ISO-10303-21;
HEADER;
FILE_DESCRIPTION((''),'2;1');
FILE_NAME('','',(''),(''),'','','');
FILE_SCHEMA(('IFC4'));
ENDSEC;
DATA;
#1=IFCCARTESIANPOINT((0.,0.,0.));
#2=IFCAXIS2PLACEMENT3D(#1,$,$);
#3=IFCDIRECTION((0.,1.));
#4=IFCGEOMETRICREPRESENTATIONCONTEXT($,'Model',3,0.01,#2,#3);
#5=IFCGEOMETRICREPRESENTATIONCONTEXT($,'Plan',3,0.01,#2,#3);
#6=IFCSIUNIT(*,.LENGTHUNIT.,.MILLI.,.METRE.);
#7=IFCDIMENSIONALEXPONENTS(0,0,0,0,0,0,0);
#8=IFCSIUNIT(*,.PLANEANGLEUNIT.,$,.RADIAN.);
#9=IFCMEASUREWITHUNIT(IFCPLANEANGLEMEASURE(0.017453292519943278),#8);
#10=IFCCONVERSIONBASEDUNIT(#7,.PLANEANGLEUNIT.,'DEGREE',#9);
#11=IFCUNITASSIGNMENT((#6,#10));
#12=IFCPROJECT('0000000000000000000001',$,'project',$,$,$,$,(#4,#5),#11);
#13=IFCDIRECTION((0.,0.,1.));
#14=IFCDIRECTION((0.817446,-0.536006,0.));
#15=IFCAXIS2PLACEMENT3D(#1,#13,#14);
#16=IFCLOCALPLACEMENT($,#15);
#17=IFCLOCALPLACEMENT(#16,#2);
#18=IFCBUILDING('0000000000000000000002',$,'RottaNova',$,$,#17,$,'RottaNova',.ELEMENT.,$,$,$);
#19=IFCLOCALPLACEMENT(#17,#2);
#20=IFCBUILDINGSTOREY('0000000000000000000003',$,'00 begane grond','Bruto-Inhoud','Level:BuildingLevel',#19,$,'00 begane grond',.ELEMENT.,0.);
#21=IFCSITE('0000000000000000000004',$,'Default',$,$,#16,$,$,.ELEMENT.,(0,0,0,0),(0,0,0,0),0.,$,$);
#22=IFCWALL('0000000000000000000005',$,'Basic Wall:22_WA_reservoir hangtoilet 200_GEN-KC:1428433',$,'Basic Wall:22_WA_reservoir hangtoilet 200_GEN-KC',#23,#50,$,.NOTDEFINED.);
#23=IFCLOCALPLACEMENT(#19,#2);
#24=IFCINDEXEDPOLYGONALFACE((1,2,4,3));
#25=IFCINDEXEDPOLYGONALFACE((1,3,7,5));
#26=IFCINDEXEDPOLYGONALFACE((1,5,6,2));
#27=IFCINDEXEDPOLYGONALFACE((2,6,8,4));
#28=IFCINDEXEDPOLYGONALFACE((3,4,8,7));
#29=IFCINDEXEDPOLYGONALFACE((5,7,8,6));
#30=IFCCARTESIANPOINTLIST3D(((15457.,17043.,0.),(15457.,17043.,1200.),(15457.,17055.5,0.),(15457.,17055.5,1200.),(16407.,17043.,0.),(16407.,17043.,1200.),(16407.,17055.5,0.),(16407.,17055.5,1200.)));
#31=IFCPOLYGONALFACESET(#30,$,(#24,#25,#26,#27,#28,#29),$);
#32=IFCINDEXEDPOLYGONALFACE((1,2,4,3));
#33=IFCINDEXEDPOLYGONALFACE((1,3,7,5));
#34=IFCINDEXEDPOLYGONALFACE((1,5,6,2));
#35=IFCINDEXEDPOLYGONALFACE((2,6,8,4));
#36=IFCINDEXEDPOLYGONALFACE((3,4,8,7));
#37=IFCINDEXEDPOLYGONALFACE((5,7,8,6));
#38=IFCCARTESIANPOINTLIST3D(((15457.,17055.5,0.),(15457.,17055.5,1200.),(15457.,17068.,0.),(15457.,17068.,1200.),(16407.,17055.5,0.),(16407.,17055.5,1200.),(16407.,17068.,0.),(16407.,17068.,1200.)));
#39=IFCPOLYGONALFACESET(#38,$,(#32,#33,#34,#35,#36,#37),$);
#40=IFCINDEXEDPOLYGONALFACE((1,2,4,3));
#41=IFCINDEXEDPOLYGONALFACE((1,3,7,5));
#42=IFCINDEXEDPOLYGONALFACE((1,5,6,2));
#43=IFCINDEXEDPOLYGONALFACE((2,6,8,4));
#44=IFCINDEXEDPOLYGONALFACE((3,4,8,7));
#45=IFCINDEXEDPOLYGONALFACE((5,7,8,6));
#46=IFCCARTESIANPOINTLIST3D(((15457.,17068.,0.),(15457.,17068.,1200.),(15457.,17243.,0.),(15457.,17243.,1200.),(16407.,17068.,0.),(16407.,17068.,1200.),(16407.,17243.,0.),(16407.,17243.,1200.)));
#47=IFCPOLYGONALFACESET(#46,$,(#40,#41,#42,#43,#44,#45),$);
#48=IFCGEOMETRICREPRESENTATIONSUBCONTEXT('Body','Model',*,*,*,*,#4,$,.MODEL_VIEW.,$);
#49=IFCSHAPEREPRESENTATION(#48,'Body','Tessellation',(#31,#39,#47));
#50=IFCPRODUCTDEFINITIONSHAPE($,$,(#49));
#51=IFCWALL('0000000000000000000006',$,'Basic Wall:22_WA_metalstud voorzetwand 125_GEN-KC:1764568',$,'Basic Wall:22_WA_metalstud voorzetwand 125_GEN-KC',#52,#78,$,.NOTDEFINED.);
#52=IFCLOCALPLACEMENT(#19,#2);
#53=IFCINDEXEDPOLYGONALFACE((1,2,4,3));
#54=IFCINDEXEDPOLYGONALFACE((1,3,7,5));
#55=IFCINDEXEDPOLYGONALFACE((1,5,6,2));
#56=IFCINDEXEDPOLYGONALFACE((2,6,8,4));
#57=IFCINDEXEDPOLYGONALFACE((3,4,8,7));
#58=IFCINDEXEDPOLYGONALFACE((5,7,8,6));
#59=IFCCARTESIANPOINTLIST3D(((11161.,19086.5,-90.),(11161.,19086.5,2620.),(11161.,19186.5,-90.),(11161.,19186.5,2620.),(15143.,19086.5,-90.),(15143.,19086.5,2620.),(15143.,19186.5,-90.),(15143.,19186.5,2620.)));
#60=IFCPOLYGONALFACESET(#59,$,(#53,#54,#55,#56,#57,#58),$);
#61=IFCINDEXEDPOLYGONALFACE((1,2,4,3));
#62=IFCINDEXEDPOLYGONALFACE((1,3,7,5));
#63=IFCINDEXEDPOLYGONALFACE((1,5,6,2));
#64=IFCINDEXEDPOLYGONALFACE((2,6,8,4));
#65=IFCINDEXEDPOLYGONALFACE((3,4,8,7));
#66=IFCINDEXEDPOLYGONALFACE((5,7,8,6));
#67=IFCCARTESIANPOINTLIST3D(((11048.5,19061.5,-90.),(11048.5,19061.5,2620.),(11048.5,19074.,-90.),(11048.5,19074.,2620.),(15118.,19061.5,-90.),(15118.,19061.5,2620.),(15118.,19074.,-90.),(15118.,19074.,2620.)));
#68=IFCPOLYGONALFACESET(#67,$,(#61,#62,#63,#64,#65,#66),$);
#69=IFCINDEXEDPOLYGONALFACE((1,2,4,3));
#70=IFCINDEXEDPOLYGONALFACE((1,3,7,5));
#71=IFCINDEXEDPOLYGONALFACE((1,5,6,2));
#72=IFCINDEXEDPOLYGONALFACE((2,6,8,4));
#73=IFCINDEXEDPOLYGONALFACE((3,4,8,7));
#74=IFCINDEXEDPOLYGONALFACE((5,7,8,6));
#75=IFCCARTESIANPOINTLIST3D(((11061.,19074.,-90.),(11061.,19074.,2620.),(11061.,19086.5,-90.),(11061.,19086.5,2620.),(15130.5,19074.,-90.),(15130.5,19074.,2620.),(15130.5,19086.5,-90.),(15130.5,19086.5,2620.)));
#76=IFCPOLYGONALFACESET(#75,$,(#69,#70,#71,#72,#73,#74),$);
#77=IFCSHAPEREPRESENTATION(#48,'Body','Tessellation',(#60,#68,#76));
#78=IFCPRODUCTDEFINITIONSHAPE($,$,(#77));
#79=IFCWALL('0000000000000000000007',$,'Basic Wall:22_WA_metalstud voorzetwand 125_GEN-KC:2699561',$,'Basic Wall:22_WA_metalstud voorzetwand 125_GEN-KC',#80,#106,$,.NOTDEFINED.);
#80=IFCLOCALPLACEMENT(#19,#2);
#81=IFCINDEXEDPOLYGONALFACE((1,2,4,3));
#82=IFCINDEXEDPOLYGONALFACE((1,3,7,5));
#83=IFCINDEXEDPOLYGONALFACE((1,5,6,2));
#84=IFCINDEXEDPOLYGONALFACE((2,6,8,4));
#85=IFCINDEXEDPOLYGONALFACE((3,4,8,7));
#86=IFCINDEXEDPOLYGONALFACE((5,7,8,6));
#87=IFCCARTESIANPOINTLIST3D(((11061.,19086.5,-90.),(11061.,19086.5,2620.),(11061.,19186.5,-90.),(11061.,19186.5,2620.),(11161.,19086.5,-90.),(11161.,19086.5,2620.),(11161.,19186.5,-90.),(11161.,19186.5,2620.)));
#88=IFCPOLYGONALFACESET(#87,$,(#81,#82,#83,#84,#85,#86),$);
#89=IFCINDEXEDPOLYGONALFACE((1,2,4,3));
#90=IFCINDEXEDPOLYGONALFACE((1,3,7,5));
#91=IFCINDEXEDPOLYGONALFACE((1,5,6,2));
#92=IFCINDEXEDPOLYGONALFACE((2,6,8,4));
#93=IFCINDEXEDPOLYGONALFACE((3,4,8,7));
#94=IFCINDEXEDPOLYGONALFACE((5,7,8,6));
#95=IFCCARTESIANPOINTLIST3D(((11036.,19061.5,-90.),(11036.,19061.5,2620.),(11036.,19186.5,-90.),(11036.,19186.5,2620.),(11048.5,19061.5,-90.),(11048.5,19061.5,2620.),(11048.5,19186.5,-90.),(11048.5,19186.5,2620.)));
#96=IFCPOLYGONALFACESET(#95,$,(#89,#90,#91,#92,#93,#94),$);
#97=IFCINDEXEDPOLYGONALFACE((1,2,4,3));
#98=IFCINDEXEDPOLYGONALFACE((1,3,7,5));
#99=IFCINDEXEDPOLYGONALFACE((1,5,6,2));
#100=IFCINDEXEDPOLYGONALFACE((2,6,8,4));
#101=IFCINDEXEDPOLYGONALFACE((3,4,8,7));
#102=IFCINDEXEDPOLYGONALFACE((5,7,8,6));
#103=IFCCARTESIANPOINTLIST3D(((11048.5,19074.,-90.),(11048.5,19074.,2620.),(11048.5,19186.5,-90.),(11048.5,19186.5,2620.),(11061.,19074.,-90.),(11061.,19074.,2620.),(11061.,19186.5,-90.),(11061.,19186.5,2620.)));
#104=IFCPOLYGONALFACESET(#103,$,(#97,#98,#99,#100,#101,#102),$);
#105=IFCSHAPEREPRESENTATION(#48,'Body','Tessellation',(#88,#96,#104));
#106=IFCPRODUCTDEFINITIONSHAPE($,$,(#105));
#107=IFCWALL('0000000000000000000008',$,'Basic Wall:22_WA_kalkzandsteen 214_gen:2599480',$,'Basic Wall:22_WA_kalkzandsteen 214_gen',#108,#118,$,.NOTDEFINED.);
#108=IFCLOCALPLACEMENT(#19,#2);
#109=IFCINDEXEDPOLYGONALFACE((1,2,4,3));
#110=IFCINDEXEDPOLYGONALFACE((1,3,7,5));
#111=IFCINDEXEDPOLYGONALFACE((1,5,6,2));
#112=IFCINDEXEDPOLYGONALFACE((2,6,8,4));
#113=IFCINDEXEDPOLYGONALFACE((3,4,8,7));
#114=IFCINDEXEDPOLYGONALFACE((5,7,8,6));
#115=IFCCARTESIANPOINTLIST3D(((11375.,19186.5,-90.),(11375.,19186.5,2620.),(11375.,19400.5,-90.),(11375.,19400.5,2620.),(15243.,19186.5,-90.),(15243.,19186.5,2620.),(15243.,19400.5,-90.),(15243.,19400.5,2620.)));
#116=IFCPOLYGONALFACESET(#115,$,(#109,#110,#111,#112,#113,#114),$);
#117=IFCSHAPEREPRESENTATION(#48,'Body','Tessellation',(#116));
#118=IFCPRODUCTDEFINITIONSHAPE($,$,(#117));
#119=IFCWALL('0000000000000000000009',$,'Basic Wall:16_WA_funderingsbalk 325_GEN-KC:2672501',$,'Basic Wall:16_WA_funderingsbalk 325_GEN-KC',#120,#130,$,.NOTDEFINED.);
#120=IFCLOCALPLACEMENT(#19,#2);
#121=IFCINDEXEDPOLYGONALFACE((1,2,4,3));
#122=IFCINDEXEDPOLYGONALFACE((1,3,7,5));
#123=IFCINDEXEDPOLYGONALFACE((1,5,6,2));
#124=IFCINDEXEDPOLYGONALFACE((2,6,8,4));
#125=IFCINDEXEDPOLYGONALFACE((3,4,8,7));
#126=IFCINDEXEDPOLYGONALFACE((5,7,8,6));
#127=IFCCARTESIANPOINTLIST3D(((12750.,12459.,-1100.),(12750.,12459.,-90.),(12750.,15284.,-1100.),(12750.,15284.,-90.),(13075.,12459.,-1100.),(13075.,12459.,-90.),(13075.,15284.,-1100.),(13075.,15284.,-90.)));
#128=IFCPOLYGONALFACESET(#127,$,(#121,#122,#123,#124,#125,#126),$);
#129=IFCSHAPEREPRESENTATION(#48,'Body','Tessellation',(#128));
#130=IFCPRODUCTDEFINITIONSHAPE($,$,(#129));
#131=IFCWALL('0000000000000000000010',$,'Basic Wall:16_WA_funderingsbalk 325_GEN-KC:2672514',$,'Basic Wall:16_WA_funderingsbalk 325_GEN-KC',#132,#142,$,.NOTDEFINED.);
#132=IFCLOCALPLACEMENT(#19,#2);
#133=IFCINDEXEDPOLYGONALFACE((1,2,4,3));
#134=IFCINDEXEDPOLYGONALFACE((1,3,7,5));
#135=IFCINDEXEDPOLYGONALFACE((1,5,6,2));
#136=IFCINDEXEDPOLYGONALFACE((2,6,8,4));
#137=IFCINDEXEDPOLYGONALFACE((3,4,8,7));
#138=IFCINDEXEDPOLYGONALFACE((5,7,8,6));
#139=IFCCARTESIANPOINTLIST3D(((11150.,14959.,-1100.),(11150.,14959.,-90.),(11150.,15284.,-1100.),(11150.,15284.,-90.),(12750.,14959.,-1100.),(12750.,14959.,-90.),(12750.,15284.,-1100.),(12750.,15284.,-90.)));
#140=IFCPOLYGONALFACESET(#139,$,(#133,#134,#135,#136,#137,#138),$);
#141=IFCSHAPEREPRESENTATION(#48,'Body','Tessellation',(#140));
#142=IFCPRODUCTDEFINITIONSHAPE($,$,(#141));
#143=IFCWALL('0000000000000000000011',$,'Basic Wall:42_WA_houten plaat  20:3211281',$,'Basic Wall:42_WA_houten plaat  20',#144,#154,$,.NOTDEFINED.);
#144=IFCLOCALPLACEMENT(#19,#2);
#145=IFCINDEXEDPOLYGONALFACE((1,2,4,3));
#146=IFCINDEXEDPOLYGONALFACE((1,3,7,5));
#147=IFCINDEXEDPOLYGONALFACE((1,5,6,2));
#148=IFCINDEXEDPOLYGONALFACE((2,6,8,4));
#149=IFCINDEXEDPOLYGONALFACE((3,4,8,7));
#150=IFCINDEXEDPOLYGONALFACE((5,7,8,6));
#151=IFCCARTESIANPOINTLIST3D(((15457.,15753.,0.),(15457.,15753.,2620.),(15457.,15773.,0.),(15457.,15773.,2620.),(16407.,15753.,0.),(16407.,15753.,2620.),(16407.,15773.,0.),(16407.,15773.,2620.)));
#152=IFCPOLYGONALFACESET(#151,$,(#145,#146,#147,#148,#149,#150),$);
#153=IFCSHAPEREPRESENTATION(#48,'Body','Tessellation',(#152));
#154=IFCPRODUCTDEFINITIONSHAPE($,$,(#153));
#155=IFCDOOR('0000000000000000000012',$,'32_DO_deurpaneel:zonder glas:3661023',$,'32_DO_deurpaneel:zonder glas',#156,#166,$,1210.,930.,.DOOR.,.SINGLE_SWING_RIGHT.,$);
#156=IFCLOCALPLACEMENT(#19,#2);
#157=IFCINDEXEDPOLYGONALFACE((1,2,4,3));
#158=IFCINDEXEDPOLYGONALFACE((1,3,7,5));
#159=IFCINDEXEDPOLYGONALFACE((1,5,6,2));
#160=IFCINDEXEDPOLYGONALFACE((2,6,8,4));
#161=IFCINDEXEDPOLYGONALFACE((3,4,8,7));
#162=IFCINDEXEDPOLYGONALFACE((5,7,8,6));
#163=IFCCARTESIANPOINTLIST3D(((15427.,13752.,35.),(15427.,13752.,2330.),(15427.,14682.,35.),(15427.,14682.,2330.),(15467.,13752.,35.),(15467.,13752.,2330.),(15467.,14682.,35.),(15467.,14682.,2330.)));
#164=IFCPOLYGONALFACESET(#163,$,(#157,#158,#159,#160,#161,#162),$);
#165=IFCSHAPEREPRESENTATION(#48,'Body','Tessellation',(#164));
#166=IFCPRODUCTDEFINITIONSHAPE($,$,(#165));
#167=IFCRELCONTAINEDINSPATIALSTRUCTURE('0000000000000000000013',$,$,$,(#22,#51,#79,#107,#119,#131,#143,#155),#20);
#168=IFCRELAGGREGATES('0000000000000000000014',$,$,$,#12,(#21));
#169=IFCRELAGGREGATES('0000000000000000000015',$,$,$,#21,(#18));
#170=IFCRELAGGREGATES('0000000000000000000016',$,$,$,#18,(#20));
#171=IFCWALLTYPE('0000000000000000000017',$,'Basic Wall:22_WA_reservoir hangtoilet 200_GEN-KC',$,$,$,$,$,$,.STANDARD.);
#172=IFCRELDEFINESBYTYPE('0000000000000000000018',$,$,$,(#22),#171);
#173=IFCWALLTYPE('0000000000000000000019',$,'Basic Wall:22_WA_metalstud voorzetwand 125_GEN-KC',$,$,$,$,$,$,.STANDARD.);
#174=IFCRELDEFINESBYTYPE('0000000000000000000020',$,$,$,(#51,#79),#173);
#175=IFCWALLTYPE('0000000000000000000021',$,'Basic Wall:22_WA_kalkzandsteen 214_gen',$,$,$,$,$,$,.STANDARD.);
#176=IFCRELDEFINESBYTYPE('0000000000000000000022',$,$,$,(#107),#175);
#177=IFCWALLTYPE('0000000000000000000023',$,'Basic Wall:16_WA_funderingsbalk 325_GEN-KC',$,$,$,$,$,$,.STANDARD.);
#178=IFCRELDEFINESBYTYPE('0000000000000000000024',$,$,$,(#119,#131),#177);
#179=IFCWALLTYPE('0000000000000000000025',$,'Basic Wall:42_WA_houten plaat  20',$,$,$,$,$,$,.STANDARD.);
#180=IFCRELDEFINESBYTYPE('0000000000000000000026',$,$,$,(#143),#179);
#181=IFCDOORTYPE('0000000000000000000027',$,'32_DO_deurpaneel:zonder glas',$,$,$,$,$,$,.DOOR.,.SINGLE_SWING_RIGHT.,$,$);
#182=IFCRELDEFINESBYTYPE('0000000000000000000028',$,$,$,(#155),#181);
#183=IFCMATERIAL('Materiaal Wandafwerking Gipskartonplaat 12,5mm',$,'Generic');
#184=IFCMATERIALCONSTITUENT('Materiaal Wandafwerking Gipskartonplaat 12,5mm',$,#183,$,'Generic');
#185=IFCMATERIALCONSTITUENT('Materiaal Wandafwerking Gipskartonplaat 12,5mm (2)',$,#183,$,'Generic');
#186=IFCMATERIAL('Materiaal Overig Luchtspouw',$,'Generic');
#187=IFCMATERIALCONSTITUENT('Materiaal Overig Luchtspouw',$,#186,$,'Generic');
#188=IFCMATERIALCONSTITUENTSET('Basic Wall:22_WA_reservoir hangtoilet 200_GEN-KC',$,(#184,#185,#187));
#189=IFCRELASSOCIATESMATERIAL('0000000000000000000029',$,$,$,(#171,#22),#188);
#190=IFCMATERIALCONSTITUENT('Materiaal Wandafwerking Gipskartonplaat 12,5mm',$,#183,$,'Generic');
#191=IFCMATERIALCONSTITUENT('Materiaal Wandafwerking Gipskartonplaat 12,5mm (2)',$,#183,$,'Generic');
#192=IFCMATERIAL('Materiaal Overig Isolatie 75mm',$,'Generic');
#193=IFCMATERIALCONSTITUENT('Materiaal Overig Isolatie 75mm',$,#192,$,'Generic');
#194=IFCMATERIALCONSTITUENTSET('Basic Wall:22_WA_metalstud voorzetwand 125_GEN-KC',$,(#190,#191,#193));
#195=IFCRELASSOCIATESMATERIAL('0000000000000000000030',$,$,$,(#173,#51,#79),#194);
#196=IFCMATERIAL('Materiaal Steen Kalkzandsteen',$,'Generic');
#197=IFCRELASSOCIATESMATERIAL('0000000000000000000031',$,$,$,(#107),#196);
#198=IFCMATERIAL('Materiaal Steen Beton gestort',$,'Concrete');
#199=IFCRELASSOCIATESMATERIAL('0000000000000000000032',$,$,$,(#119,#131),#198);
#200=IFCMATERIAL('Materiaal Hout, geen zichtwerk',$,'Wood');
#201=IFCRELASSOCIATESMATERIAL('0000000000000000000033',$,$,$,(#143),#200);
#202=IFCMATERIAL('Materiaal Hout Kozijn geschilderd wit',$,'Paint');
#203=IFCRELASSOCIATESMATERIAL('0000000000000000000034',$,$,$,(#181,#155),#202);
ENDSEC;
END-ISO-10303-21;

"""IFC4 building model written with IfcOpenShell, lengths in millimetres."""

from ifc_helpers import new_model, entity, si_unit, converted_unit, direction, frame, origin, place, context, subcontext, project, spatial, indexed_curve, outline, extrude, source, transform, mapped, material, constituent, constituent_set, type_object, type_shapes, element, save


model = new_model("IFC4")

# Units and contexts
model_context = context("Model", 3, precision=0.01, world=origin(), true_north=direction((0.0, 1.0)))
plan_context = context("Plan", 3, precision=0.01, world=origin(), true_north=direction((0.0, 1.0)))
body_context = subcontext(model_context, "Body", "Model", "MODEL_VIEW")
ifc_project = project(units=[si_unit("LENGTHUNIT", "METRE", prefix="MILLI"), converted_unit("PLANEANGLEUNIT", "DEGREE", entity("IfcPlaneAngleMeasure", 0.017453292519943278), si_unit("PLANEANGLEUNIT", "RADIAN"), dimensions=[0, 0, 0, 0, 0, 0, 0])], contexts=[model_context, plan_context])

# Site, building, storey
site_placement = place(None, frame((0.0, 0.0, 0.0), z_axis=(0.0, 0.0, 1.0), x_axis=(0.817446, -0.536006, 0.0)))
site = spatial("IfcSite", under=ifc_project, at=site_placement, Name="Default", CompositionType="ELEMENT", RefLatitude=(0, 0, 0, 0), RefLongitude=(0, 0, 0, 0), RefElevation=0.0)
building_placement = place(site_placement, origin())
building = spatial("IfcBuilding", under=site, at=building_placement, Name="RottaNova", LongName="RottaNova", CompositionType="ELEMENT")
storey_placement = place(building_placement, origin())
storey = spatial("IfcBuildingStorey", under=building, at=storey_placement, Name="00 begane grond", Description="Bruto-Inhoud", ObjectType="Level:BuildingLevel", LongName="00 begane grond", CompositionType="ELEMENT", Elevation=0.0)

# Walls
ifc_material_1 = material(Name="Materiaal Steen Kalkzandsteen", Category="Generic")
ifc_material_2 = material(Name="Materiaal Wandafwerking Gipskartonplaat 12,5mm", Category="Generic")
ifc_constituent_1 = constituent(ifc_material_2, Name="Materiaal Wandafwerking Gipskartonplaat 12,5mm", Category="Generic")
ifc_constituent_2 = constituent(ifc_material_2, Name="Materiaal Wandafwerking Gipskartonplaat 12,5mm (2)", Category="Generic")
ifc_material_3 = material(Name="Materiaal Overig Luchtspouw", Category="Generic")
ifc_constituent_3 = constituent(ifc_material_3, Name="Materiaal Overig Luchtspouw", Category="Generic")
ifc_constituent_set_1 = constituent_set(constituents=[ifc_constituent_1, ifc_constituent_2, ifc_constituent_3], Name="Basic Wall:22_WA_reservoir hangtoilet 200_GEN-KC")
wall_type_1 = type_object("IfcWallType", Name="Basic Wall:22_WA_reservoir hangtoilet 200_GEN-KC", PredefinedType="STANDARD", material=ifc_constituent_set_1)
wall_1_placement = place(storey_placement, frame((16407.0, 17143.0, 0.0), z_axis=(0.0, 0.0, 1.0), x_axis=(-1.0, 0.0, 0.0)))
element("IfcWall", 1, at=wall_1_placement, inside=storey, type_object=wall_type_1, material=ifc_constituent_set_1, Name="Basic Wall:22_WA_reservoir hangtoilet 200_GEN-KC:1428433", ObjectType="Basic Wall:22_WA_reservoir hangtoilet 200_GEN-KC", PredefinedType="NOTDEFINED", context=body_context, shape_type="SweptSolid", body=[
    extrude(outline(indexed_curve([(-6.3, -475.0), (6.2, -475.0), (6.3, 475.0), (-6.2, 475.0), (-6.3, -475.0)], self_intersect=False)), frame((475.0, 93.7, 0.0), z_axis=(0.0, 0.0, 1.0), x_axis=(0.0, -1.0, 0.0)), (0.0, 0.0, 1.0), 1200.0),
    extrude(outline(indexed_curve([(-475.0, -6.2), (475.0, -6.2), (475.0, 6.2), (-475.0, 6.2), (-475.0, -6.2)], self_intersect=False)), frame((475.0, 81.2, 0.0)), (0.0, 0.0, 1.0), 1200.0),
    extrude(outline(indexed_curve([(-87.5, -475.0), (87.5, -475.0), (87.5, 475.0), (-87.5, 475.0), (-87.5, -475.0)], self_intersect=False)), frame((475.0, -12.5, 0.0), z_axis=(0.0, 0.0, 1.0), x_axis=(0.0, 1.0, 0.0)), (0.0, 0.0, 1.0), 1200.0),
])
ifc_constituent_4 = constituent(ifc_material_2, Name="Materiaal Wandafwerking Gipskartonplaat 12,5mm", Category="Generic")
ifc_constituent_5 = constituent(ifc_material_2, Name="Materiaal Wandafwerking Gipskartonplaat 12,5mm (2)", Category="Generic")
ifc_material_4 = material(Name="Materiaal Overig Isolatie 75mm", Category="Generic")
ifc_constituent_6 = constituent(ifc_material_4, Name="Materiaal Overig Isolatie 75mm", Category="Generic")
ifc_constituent_set_2 = constituent_set(constituents=[ifc_constituent_4, ifc_constituent_5, ifc_constituent_6], Name="Basic Wall:22_WA_metalstud voorzetwand 125_GEN-KC")
wall_type_2 = type_object("IfcWallType", Name="Basic Wall:22_WA_metalstud voorzetwand 125_GEN-KC", PredefinedType="STANDARD", material=ifc_constituent_set_2)
wall_2_placement = place(storey_placement, frame((11161.0, 19124.0, -90.0)))
element("IfcWall", 2, at=wall_2_placement, inside=storey, type_object=wall_type_2, material=ifc_constituent_set_2, Name="Basic Wall:22_WA_metalstud voorzetwand 125_GEN-KC:1764568", ObjectType="Basic Wall:22_WA_metalstud voorzetwand 125_GEN-KC", PredefinedType="NOTDEFINED", context=body_context, shape_type="SweptSolid", body=[
    extrude(outline(indexed_curve([(-50.0, -1991.0), (50.0, -1991.0), (50.0, 1991.0), (-50.0, 1991.0), (-50.0, -1991.0)], self_intersect=False)), frame((1991.0, 12.5, 0.0), z_axis=(0.0, 0.0, 1.0), x_axis=(0.0, -1.0, 0.0)), (0.0, 0.0, 1.0), 2710.0),
    extrude(outline(indexed_curve([(-6.2, -2034.8), (6.3, -2034.8), (6.2, 2034.8), (-6.3, 2034.8), (-6.2, -2034.8)], self_intersect=False)), frame((1922.3, -56.2, 0.0), z_axis=(0.0, 0.0, 1.0), x_axis=(0.0, 1.0, 0.0)), (0.0, 0.0, 1.0), 2710.0),
    extrude(outline(indexed_curve([(-2034.8, -6.3), (2034.8, -6.2), (2034.8, 6.3), (-2034.8, 6.2), (-2034.8, -6.3)], self_intersect=False)), frame((1934.8, -43.7, 0.0)), (0.0, 0.0, 1.0), 2710.0),
])
wall_3_placement = place(storey_placement, frame((11098.5, 19061.5, -90.0), z_axis=(0.0, 0.0, 1.0), x_axis=(0.0, 1.0, 0.0)))
element("IfcWall", 3, at=wall_3_placement, inside=storey, type_object=wall_type_2, material=ifc_constituent_set_2, Name="Basic Wall:22_WA_metalstud voorzetwand 125_GEN-KC:2699561", ObjectType="Basic Wall:22_WA_metalstud voorzetwand 125_GEN-KC", PredefinedType="NOTDEFINED", context=body_context, shape_type="SweptSolid", body=[
    extrude(outline(indexed_curve([(-50.0, -50.0), (50.0, -50.0), (50.0, 50.0), (-50.0, 50.0), (-50.0, -50.0)], self_intersect=False)), frame((75.0, -12.5, 0.0), z_axis=(0.0, 0.0, 1.0), x_axis=(0.0, 1.0, 0.0)), (0.0, 0.0, 1.0), 2710.0),
    extrude(outline(indexed_curve([(-6.3, -62.5), (6.3, -62.5), (6.3, 62.5), (-6.3, 62.5), (-6.3, -62.5)], self_intersect=False)), frame((62.5, 56.3, 0.0), z_axis=(0.0, 0.0, 1.0), x_axis=(0.0, -1.0, 0.0)), (0.0, 0.0, 1.0), 2710.0),
    extrude(outline(indexed_curve([(-56.3, -6.3), (56.3, -6.3), (56.3, 6.2), (-56.3, 6.2), (-56.3, -6.3)], self_intersect=False)), frame((68.8, 43.8, 0.0)), (0.0, 0.0, 1.0), 2710.0),
])
wall_type_3 = type_object("IfcWallType", Name="Basic Wall:22_WA_kalkzandsteen 214_gen", PredefinedType="STANDARD")
wall_4_placement = place(storey_placement, frame((11375.0, 19293.5, -90.0)))
element("IfcWall", 4, at=wall_4_placement, inside=storey, type_object=wall_type_3, material=ifc_material_1, Name="Basic Wall:22_WA_kalkzandsteen 214_gen:2599480", ObjectType="Basic Wall:22_WA_kalkzandsteen 214_gen", PredefinedType="NOTDEFINED", context=body_context, shape_type="SweptSolid", body=[
    extrude(outline(indexed_curve([(3868.0, 107.0), (0.0, 107.0), (0.0, -107.0), (3868.0, -107.0), (3868.0, 107.0)], self_intersect=False)), origin(), (0.0, 0.0, 1.0), 2710.0),
])
ifc_material_5 = material(Name="Materiaal Steen Beton gestort", Category="Concrete")
wall_type_4 = type_object("IfcWallType", Name="Basic Wall:16_WA_funderingsbalk 325_GEN-KC", PredefinedType="STANDARD")
wall_5_placement = place(storey_placement, frame((12912.5, 12459.0, -1100.0), z_axis=(0.0, 0.0, 1.0), x_axis=(0.0, 1.0, 0.0)))
element("IfcWall", 5, at=wall_5_placement, inside=storey, type_object=wall_type_4, material=ifc_material_5, Name="Basic Wall:16_WA_funderingsbalk 325_GEN-KC:2672501", ObjectType="Basic Wall:16_WA_funderingsbalk 325_GEN-KC", PredefinedType="NOTDEFINED", context=body_context, shape_type="SweptSolid", body=[
    extrude(outline(indexed_curve([(2825.0, 162.5), (0.0, 162.5), (0.0, -162.5), (2825.0, -162.5), (2825.0, 162.5)], self_intersect=False)), origin(), (0.0, 0.0, 1.0), 1010.0),
])
wall_6_placement = place(storey_placement, frame((11150.0, 15121.5, -1100.0)))
element("IfcWall", 6, at=wall_6_placement, inside=storey, type_object=wall_type_4, material=ifc_material_5, Name="Basic Wall:16_WA_funderingsbalk 325_GEN-KC:2672514", ObjectType="Basic Wall:16_WA_funderingsbalk 325_GEN-KC", PredefinedType="NOTDEFINED", context=body_context, shape_type="SweptSolid", body=[
    extrude(outline(indexed_curve([(1600.0, 162.5), (0.0, 162.5), (0.0, -162.5), (1600.0, -162.5), (1600.0, 162.5)], self_intersect=False)), origin(), (0.0, 0.0, 1.0), 1010.0),
])
ifc_material_6 = material(Name="Materiaal Hout, geen zichtwerk", Category="Wood")
wall_type_5 = type_object("IfcWallType", Name="Basic Wall:42_WA_houten plaat  20", PredefinedType="STANDARD")
wall_7_placement = place(storey_placement, frame((16407.0, 15763.0, 0.0), z_axis=(0.0, 0.0, 1.0), x_axis=(-1.0, 0.0, 0.0)))
element("IfcWall", 7, at=wall_7_placement, inside=storey, type_object=wall_type_5, material=ifc_material_6, Name="Basic Wall:42_WA_houten plaat  20:3211281", ObjectType="Basic Wall:42_WA_houten plaat  20", PredefinedType="NOTDEFINED", context=body_context, shape_type="SweptSolid", body=[
    extrude(outline(indexed_curve([(950.0, 10.0), (0.0, 10.0), (0.0, -10.0), (950.0, -10.0), (950.0, 10.0)], self_intersect=False)), origin(), (0.0, 0.0, 1.0), 2620.0),
])

# Door
ifc_material_7 = material(Name="Materiaal Hout Kozijn geschilderd wit", Category="Paint")
door_type_1 = type_object("IfcDoorType", Name="32_DO_deurpaneel:zonder glas", OperationType="SINGLE_SWING_RIGHT", PredefinedType="DOOR", material=ifc_material_7)
shared_shape_1 = source(origin(), body_context, "Body", "SweptSolid", [
    extrude(outline(indexed_curve([(-1147.5, -20.0), (1147.5, -20.0), (1147.5, 20.0), (-1147.5, 20.0), (-1147.5, -20.0)], self_intersect=False)), frame((-465.0, 20.0, 1182.5), z_axis=(1.0, 0.0, 0.0), x_axis=(0.0, 0.0, 1.0)), (0.0, 0.0, 1.0), 930.0),
])
type_shapes(door_type_1, [shared_shape_1])
door_1_placement = place(storey_placement, frame((15427.0, 14217.0, 0.0), z_axis=(0.0, 0.0, 1.0), x_axis=(0.0, -1.0, 0.0)))
element("IfcDoor", 8, at=door_1_placement, inside=storey, type_object=door_type_1, material=ifc_material_7, Name="32_DO_deurpaneel:zonder glas:3661023", ObjectType="32_DO_deurpaneel:zonder glas", OperationType="SINGLE_SWING_RIGHT", OverallHeight=1210.0, OverallWidth=930.0, PredefinedType="DOOR", context=body_context, shape_type="MappedRepresentation", body=[
    mapped(shared_shape_1, transform((0.0, 0.0, 0.0), scale=1.0)),
])

save(model, "model.ifc")
